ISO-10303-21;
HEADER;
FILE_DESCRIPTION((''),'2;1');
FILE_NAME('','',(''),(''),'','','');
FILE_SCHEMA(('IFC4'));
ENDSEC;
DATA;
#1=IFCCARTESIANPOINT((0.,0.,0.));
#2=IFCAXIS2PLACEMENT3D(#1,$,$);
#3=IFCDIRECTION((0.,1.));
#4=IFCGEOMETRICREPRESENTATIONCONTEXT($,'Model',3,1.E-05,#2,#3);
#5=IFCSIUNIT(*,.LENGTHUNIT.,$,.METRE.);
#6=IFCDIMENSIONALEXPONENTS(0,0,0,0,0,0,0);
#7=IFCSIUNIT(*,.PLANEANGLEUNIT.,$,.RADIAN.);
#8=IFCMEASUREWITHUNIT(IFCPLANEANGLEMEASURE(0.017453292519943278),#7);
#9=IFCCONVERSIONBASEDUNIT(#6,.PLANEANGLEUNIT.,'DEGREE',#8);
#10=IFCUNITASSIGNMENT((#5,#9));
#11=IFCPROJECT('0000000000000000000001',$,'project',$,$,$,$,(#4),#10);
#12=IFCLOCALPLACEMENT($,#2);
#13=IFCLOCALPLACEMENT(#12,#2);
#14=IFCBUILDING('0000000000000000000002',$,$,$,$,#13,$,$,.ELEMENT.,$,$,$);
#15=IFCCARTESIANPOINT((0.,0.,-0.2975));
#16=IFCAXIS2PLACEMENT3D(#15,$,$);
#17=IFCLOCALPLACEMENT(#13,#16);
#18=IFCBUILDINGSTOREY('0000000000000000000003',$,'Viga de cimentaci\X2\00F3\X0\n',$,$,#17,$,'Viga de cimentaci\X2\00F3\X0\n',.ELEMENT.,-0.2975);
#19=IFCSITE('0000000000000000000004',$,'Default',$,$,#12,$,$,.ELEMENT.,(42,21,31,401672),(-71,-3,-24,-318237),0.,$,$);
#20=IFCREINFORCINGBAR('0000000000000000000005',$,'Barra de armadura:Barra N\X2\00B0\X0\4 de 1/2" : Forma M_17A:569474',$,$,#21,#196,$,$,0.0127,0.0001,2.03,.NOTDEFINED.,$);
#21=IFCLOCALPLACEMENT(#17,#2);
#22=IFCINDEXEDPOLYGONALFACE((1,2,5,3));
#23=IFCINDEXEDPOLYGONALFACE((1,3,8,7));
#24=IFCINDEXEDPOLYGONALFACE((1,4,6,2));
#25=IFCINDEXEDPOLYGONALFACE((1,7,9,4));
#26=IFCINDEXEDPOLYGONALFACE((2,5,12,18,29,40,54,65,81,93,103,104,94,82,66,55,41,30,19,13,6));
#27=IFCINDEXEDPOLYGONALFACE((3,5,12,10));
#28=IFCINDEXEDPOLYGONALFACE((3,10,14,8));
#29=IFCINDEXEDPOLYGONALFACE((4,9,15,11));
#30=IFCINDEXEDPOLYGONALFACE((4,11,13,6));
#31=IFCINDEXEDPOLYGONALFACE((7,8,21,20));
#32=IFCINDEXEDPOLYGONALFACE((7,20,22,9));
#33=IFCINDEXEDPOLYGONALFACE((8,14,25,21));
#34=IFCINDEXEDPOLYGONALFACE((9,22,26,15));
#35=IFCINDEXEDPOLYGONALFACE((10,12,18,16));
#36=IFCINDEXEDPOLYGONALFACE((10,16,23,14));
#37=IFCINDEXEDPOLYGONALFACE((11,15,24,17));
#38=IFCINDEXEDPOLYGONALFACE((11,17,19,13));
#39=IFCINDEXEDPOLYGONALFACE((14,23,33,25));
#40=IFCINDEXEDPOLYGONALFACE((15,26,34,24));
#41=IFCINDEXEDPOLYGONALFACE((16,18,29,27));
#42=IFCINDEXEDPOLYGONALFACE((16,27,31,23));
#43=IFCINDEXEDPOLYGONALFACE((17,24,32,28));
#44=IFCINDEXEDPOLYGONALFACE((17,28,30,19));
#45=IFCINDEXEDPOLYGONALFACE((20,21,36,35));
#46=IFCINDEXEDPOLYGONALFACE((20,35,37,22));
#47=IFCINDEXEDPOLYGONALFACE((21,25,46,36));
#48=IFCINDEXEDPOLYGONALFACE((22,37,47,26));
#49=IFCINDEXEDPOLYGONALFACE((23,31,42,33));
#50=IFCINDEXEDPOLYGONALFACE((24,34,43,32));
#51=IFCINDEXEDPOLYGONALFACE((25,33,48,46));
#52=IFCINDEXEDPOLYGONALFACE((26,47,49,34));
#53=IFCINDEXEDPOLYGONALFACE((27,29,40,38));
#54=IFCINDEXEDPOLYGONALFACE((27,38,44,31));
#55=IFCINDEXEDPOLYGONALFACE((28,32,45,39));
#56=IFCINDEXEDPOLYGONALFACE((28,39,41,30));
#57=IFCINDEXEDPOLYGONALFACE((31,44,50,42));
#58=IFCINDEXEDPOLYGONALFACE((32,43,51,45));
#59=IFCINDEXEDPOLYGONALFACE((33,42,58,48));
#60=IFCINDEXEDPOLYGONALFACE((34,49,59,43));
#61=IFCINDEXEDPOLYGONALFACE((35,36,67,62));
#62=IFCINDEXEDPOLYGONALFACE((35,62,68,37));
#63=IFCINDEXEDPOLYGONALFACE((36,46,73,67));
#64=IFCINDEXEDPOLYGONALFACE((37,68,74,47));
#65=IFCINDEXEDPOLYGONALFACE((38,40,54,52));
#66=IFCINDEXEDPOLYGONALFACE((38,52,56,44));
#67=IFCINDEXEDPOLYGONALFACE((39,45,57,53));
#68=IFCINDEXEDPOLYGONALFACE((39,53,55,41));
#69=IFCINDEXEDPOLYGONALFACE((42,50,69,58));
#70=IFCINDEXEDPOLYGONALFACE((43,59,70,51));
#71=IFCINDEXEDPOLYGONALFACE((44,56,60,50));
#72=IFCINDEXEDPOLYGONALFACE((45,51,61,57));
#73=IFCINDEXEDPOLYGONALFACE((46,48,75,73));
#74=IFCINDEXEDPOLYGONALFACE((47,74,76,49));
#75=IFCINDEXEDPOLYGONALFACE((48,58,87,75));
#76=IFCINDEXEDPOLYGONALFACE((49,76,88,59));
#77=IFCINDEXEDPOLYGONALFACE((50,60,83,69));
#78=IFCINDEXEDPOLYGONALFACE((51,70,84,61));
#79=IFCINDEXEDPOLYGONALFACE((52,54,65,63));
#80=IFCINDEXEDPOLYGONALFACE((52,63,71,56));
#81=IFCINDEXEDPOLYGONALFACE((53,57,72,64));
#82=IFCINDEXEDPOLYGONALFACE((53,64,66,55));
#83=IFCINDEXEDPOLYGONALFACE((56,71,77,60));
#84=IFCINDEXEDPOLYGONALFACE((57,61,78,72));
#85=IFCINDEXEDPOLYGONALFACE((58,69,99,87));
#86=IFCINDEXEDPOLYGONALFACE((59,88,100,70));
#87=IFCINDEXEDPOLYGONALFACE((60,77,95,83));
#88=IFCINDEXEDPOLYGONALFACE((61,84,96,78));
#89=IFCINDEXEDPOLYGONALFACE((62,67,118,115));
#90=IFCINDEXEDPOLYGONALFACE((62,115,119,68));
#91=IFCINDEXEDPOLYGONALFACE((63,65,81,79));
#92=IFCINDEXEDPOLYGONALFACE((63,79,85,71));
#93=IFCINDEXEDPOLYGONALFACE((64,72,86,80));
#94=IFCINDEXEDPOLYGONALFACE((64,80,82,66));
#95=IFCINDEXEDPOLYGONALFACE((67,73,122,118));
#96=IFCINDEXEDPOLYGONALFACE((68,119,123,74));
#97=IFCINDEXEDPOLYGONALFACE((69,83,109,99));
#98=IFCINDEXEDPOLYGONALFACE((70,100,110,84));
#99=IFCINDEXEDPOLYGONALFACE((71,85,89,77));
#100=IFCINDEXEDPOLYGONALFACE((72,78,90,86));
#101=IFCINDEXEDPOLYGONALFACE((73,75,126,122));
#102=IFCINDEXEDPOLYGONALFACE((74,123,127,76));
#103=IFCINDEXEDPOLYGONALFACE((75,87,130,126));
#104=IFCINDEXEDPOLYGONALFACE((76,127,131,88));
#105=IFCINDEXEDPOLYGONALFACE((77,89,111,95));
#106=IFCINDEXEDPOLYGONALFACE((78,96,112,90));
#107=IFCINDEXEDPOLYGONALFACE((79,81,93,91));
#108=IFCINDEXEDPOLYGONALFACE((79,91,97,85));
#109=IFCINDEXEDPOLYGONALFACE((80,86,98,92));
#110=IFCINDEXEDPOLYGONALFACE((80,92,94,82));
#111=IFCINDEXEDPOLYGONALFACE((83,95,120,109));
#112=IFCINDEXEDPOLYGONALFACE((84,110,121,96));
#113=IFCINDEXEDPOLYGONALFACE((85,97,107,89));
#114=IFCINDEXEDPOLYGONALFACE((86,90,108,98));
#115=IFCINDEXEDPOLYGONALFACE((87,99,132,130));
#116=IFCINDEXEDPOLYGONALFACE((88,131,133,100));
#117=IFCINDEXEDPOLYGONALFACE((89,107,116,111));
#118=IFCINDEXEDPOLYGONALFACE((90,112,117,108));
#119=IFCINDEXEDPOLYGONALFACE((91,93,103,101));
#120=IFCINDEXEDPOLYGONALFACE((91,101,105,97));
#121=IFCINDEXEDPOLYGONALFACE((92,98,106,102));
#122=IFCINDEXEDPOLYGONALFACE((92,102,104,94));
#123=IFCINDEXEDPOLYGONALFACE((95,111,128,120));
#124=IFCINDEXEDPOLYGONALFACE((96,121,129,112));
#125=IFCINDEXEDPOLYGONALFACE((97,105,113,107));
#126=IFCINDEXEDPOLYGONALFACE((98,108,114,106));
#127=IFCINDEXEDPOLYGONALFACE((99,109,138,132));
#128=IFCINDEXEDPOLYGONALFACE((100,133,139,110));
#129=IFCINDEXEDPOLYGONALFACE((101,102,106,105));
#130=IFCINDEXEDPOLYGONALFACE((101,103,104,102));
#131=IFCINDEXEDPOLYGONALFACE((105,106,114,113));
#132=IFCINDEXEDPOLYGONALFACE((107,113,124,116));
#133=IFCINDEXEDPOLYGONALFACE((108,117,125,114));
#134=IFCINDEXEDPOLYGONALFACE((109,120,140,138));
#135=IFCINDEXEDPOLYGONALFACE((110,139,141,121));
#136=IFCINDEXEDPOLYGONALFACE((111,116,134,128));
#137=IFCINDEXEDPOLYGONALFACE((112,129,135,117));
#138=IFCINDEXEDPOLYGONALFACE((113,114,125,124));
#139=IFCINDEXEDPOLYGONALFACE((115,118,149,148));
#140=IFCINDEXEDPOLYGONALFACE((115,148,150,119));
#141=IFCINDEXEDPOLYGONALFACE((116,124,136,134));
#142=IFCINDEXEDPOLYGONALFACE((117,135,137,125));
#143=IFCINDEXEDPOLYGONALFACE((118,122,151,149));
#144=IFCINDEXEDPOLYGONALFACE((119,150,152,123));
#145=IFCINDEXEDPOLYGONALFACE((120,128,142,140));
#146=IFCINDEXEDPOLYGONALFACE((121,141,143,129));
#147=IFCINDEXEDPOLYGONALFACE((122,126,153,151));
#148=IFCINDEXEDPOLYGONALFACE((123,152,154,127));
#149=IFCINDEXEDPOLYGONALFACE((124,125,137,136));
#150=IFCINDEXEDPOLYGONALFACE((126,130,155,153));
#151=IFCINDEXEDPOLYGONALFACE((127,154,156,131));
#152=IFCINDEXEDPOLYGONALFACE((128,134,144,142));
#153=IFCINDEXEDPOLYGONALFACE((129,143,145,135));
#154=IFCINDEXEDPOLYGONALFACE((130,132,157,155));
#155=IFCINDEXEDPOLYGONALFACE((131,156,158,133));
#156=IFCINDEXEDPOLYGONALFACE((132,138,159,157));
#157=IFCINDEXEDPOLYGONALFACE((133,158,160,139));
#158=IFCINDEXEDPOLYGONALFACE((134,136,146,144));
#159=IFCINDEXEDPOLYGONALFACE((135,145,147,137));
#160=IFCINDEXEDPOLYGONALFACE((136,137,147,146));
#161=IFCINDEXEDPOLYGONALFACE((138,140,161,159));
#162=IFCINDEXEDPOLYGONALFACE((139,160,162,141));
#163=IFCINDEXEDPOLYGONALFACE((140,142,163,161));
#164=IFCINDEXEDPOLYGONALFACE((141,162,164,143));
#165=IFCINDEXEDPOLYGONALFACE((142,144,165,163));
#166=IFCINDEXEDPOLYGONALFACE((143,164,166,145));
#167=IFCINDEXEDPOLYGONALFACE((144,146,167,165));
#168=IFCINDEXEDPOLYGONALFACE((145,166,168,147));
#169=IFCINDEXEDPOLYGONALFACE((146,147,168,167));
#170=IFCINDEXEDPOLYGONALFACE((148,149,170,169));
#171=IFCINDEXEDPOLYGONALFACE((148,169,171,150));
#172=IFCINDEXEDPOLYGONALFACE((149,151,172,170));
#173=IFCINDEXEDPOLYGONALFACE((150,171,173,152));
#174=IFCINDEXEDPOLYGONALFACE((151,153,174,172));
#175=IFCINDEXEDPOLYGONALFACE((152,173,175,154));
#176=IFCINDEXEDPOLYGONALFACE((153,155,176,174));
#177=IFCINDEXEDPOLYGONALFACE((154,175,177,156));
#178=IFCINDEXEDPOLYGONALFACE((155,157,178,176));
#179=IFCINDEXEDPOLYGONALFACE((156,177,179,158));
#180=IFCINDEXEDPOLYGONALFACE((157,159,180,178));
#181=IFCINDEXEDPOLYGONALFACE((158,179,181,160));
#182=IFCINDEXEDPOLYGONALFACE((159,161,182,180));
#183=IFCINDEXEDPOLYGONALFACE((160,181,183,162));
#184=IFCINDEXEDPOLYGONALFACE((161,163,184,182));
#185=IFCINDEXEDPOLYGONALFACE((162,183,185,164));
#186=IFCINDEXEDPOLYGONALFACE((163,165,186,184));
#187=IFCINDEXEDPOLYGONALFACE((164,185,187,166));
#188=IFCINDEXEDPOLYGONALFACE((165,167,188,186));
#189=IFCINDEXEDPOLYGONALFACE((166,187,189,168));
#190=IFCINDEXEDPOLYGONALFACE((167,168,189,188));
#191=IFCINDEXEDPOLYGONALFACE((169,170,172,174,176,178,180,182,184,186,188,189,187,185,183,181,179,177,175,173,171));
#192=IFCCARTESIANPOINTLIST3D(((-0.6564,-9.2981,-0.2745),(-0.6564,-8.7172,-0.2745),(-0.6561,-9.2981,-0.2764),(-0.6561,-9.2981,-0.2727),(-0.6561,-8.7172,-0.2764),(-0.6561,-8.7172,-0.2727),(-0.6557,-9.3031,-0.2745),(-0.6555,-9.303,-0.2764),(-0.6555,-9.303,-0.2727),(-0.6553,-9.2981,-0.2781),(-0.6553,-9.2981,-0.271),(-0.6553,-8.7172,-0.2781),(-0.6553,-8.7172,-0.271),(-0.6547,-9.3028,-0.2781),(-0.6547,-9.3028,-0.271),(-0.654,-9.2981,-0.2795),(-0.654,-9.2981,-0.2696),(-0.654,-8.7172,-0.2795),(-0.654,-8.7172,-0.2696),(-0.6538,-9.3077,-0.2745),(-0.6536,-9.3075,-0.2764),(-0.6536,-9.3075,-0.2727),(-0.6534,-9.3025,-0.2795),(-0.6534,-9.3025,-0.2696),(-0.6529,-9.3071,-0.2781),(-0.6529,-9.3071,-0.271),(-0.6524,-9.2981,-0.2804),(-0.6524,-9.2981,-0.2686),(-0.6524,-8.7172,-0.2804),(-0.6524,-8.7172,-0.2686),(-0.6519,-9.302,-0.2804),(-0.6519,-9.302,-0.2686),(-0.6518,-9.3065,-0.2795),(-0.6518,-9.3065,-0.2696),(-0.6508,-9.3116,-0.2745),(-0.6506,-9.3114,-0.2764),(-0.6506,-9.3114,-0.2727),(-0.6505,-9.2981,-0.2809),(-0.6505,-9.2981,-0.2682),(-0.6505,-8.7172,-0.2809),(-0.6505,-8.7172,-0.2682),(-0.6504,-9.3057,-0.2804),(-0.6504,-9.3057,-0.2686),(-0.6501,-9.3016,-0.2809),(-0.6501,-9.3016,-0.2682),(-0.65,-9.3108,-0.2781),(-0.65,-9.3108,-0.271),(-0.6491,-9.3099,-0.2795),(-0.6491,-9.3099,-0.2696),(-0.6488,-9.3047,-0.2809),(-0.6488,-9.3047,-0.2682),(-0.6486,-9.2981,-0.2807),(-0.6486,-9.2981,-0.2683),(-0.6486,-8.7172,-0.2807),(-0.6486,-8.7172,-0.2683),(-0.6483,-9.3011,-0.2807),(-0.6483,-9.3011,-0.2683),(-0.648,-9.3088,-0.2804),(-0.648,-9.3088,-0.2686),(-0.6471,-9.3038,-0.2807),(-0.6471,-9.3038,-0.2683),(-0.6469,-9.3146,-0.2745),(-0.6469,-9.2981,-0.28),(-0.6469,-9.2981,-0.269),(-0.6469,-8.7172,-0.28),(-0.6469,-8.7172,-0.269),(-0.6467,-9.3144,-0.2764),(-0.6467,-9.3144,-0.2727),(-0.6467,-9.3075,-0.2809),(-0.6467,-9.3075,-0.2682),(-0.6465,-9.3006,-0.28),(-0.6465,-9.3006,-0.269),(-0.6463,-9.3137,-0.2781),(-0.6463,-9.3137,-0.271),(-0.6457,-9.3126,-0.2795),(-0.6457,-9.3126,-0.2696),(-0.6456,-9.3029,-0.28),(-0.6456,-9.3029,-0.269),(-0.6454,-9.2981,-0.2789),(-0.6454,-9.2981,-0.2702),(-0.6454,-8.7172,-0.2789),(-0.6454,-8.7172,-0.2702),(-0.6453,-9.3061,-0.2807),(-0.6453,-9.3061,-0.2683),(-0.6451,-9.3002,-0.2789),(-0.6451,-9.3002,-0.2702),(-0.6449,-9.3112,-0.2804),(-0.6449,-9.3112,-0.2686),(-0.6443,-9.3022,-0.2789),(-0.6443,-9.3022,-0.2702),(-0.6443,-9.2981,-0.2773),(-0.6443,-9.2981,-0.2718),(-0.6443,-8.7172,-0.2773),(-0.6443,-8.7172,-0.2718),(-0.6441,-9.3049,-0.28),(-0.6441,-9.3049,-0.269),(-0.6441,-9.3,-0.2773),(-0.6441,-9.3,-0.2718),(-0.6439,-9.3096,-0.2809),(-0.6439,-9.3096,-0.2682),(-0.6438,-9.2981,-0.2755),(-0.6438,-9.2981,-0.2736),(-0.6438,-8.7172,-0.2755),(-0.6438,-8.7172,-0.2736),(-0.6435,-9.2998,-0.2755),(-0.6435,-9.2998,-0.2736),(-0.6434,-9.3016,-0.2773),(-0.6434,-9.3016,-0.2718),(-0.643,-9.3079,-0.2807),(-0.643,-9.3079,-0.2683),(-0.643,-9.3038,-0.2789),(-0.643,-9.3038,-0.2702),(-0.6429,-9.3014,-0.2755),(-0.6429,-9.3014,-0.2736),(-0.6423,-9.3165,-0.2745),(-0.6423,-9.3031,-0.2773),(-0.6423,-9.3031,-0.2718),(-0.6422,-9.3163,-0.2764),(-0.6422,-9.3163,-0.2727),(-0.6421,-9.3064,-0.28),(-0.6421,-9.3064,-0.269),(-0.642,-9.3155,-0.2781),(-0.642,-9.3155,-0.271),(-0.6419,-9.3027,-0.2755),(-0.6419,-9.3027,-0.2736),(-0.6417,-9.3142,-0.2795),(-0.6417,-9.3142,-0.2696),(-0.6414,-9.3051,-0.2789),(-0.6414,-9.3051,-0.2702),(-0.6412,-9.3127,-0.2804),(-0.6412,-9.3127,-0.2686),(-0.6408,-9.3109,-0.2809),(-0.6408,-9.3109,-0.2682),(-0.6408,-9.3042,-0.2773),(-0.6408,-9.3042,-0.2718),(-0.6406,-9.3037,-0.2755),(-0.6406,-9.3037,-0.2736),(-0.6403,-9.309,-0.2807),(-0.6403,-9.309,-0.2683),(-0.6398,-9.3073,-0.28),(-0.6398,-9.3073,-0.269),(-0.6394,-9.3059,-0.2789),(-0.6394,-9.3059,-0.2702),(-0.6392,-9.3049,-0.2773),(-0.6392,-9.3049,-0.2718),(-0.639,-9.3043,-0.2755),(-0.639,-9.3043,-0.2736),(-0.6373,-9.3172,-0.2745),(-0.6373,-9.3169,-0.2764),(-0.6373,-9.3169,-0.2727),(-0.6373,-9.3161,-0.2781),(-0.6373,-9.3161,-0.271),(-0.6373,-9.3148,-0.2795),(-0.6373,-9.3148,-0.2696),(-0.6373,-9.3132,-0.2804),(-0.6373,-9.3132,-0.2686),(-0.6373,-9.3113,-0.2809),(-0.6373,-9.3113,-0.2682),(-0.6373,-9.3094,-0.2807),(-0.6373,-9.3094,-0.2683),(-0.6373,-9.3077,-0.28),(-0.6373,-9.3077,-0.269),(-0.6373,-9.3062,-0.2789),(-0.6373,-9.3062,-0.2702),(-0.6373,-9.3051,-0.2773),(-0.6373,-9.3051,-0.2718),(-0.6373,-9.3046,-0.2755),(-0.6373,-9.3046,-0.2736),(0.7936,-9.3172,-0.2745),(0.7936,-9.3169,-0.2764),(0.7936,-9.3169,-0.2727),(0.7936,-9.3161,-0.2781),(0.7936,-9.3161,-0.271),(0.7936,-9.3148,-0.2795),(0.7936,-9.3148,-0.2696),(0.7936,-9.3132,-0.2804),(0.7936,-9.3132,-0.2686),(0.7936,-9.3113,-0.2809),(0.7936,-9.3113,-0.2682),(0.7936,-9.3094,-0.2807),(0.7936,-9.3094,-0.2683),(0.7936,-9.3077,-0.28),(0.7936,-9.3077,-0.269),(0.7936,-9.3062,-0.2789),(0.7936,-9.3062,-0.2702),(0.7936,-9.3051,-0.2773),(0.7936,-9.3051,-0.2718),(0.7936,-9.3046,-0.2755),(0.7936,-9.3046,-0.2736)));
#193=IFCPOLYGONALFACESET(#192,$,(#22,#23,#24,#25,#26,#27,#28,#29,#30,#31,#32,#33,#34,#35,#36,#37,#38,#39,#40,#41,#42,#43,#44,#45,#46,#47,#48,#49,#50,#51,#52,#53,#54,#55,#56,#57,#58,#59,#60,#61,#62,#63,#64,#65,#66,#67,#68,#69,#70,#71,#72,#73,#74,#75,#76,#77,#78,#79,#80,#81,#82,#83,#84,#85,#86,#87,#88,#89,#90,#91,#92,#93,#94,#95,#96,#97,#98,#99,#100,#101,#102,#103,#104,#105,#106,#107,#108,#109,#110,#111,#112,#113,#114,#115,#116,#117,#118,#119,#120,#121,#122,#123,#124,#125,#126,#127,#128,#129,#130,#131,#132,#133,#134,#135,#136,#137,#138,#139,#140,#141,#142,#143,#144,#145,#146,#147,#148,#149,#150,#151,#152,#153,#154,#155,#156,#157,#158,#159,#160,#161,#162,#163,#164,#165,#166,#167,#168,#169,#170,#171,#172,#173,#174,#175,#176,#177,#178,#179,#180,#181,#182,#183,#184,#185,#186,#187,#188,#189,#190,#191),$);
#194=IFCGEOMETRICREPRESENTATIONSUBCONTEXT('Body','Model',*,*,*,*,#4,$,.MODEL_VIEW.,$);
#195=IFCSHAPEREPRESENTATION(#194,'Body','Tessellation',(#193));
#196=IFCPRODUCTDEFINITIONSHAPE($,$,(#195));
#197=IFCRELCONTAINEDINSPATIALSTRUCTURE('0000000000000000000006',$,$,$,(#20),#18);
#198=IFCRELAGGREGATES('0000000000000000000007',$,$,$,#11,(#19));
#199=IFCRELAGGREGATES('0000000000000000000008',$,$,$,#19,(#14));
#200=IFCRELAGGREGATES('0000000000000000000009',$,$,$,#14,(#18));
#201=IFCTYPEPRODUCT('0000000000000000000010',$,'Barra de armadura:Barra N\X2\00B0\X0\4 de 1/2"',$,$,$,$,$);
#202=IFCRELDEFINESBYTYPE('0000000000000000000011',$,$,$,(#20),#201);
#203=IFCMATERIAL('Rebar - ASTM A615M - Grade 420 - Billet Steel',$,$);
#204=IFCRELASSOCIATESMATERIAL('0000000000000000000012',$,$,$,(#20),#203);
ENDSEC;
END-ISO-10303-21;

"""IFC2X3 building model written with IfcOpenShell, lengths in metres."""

from ifc_helpers import new_model, entity, si_unit, converted_unit, direction, frame, origin, place, context, subcontext, project, spatial, material, type_object, element, save


model = new_model("IFC2X3")

# Units and contexts
model_context = context("Model", 3, precision=1e-05, world=origin(), true_north=direction((0.0, 1.0)))
body_context = subcontext(model_context, "Body", "Model", "MODEL_VIEW")
ifc_project = project(units=[si_unit("LENGTHUNIT", "METRE"), converted_unit("PLANEANGLEUNIT", "DEGREE", entity("IfcPlaneAngleMeasure", 0.017453292519943278), si_unit("PLANEANGLEUNIT", "RADIAN"), dimensions=[0, 0, 0, 0, 0, 0, 0])], contexts=[model_context])

# Site, building, storey
site_placement = place(None, origin())
site = spatial("IfcSite", under=ifc_project, at=site_placement, Name="Default", CompositionType="ELEMENT", RefLatitude=(42, 21, 31, 401672), RefLongitude=(-71, -3, -24, -318237), RefElevation=0.0)
building_placement = place(site_placement, origin())
building = spatial("IfcBuilding", under=site, at=building_placement, CompositionType="ELEMENT")
storey_placement = place(building_placement, frame((0.0, 0.0, -0.2975)))
storey = spatial("IfcBuildingStorey", under=building, at=storey_placement, Name="Viga de cimentación", LongName="Viga de cimentación", CompositionType="ELEMENT", Elevation=-0.2975)

# Reinforcing bar
ifc_material = material(Name="Rebar - ASTM A615M - Grade 420 - Billet Steel")
type_product_1 = type_object("IfcTypeProduct", Name="Barra de armadura:Barra N°4 de 1/2\"")
reinforcing_bar_1_placement = place(storey_placement, origin())
element("IfcReinforcingBar", 1, at=reinforcing_bar_1_placement, inside=storey, type_object=type_product_1, material=ifc_material, Name="Barra de armadura:Barra N°4 de 1/2\" : Forma M_17A:569474", BarLength=2.03, BarRole="NOTDEFINED", CrossSectionArea=0.0001, NominalDiameter=0.0127, context=body_context, shape_type="AdvancedSweptSolid", body=[
    entity("IfcSweptDiskSolid", entity("IfcCompositeCurve", [entity("IfcCompositeCurveSegment", "CONTINUOUS", True, entity("IfcPolyline", [entity("IfcCartesianPoint", [-0.65, -8.7172, -0.2745]), entity("IfcCartesianPoint", [-0.65, -9.2981, -0.2745])])), entity("IfcCompositeCurveSegment", "CONTINUOUS", True, entity("IfcTrimmedCurve", entity("IfcCircle", entity("IfcAxis2Placement3D", entity("IfcCartesianPoint", [-0.6373, -9.2981, -0.2745]), entity("IfcDirection", [0.0, 0.0, 1.0]), entity("IfcDirection", [0.0, -1.0, 0.0])), 0.0127), [entity("IfcParameterValue", 270.0)], [entity("IfcParameterValue", 360.0)], True, "PARAMETER")), entity("IfcCompositeCurveSegment", "CONTINUOUS", True, entity("IfcPolyline", [entity("IfcCartesianPoint", [-0.6373, -9.3108, -0.2745]), entity("IfcCartesianPoint", [0.7936, -9.3108, -0.2745])]))], False), 0.0063, None, 0.0, 92.0),
])

save(model, "model.ifc")
